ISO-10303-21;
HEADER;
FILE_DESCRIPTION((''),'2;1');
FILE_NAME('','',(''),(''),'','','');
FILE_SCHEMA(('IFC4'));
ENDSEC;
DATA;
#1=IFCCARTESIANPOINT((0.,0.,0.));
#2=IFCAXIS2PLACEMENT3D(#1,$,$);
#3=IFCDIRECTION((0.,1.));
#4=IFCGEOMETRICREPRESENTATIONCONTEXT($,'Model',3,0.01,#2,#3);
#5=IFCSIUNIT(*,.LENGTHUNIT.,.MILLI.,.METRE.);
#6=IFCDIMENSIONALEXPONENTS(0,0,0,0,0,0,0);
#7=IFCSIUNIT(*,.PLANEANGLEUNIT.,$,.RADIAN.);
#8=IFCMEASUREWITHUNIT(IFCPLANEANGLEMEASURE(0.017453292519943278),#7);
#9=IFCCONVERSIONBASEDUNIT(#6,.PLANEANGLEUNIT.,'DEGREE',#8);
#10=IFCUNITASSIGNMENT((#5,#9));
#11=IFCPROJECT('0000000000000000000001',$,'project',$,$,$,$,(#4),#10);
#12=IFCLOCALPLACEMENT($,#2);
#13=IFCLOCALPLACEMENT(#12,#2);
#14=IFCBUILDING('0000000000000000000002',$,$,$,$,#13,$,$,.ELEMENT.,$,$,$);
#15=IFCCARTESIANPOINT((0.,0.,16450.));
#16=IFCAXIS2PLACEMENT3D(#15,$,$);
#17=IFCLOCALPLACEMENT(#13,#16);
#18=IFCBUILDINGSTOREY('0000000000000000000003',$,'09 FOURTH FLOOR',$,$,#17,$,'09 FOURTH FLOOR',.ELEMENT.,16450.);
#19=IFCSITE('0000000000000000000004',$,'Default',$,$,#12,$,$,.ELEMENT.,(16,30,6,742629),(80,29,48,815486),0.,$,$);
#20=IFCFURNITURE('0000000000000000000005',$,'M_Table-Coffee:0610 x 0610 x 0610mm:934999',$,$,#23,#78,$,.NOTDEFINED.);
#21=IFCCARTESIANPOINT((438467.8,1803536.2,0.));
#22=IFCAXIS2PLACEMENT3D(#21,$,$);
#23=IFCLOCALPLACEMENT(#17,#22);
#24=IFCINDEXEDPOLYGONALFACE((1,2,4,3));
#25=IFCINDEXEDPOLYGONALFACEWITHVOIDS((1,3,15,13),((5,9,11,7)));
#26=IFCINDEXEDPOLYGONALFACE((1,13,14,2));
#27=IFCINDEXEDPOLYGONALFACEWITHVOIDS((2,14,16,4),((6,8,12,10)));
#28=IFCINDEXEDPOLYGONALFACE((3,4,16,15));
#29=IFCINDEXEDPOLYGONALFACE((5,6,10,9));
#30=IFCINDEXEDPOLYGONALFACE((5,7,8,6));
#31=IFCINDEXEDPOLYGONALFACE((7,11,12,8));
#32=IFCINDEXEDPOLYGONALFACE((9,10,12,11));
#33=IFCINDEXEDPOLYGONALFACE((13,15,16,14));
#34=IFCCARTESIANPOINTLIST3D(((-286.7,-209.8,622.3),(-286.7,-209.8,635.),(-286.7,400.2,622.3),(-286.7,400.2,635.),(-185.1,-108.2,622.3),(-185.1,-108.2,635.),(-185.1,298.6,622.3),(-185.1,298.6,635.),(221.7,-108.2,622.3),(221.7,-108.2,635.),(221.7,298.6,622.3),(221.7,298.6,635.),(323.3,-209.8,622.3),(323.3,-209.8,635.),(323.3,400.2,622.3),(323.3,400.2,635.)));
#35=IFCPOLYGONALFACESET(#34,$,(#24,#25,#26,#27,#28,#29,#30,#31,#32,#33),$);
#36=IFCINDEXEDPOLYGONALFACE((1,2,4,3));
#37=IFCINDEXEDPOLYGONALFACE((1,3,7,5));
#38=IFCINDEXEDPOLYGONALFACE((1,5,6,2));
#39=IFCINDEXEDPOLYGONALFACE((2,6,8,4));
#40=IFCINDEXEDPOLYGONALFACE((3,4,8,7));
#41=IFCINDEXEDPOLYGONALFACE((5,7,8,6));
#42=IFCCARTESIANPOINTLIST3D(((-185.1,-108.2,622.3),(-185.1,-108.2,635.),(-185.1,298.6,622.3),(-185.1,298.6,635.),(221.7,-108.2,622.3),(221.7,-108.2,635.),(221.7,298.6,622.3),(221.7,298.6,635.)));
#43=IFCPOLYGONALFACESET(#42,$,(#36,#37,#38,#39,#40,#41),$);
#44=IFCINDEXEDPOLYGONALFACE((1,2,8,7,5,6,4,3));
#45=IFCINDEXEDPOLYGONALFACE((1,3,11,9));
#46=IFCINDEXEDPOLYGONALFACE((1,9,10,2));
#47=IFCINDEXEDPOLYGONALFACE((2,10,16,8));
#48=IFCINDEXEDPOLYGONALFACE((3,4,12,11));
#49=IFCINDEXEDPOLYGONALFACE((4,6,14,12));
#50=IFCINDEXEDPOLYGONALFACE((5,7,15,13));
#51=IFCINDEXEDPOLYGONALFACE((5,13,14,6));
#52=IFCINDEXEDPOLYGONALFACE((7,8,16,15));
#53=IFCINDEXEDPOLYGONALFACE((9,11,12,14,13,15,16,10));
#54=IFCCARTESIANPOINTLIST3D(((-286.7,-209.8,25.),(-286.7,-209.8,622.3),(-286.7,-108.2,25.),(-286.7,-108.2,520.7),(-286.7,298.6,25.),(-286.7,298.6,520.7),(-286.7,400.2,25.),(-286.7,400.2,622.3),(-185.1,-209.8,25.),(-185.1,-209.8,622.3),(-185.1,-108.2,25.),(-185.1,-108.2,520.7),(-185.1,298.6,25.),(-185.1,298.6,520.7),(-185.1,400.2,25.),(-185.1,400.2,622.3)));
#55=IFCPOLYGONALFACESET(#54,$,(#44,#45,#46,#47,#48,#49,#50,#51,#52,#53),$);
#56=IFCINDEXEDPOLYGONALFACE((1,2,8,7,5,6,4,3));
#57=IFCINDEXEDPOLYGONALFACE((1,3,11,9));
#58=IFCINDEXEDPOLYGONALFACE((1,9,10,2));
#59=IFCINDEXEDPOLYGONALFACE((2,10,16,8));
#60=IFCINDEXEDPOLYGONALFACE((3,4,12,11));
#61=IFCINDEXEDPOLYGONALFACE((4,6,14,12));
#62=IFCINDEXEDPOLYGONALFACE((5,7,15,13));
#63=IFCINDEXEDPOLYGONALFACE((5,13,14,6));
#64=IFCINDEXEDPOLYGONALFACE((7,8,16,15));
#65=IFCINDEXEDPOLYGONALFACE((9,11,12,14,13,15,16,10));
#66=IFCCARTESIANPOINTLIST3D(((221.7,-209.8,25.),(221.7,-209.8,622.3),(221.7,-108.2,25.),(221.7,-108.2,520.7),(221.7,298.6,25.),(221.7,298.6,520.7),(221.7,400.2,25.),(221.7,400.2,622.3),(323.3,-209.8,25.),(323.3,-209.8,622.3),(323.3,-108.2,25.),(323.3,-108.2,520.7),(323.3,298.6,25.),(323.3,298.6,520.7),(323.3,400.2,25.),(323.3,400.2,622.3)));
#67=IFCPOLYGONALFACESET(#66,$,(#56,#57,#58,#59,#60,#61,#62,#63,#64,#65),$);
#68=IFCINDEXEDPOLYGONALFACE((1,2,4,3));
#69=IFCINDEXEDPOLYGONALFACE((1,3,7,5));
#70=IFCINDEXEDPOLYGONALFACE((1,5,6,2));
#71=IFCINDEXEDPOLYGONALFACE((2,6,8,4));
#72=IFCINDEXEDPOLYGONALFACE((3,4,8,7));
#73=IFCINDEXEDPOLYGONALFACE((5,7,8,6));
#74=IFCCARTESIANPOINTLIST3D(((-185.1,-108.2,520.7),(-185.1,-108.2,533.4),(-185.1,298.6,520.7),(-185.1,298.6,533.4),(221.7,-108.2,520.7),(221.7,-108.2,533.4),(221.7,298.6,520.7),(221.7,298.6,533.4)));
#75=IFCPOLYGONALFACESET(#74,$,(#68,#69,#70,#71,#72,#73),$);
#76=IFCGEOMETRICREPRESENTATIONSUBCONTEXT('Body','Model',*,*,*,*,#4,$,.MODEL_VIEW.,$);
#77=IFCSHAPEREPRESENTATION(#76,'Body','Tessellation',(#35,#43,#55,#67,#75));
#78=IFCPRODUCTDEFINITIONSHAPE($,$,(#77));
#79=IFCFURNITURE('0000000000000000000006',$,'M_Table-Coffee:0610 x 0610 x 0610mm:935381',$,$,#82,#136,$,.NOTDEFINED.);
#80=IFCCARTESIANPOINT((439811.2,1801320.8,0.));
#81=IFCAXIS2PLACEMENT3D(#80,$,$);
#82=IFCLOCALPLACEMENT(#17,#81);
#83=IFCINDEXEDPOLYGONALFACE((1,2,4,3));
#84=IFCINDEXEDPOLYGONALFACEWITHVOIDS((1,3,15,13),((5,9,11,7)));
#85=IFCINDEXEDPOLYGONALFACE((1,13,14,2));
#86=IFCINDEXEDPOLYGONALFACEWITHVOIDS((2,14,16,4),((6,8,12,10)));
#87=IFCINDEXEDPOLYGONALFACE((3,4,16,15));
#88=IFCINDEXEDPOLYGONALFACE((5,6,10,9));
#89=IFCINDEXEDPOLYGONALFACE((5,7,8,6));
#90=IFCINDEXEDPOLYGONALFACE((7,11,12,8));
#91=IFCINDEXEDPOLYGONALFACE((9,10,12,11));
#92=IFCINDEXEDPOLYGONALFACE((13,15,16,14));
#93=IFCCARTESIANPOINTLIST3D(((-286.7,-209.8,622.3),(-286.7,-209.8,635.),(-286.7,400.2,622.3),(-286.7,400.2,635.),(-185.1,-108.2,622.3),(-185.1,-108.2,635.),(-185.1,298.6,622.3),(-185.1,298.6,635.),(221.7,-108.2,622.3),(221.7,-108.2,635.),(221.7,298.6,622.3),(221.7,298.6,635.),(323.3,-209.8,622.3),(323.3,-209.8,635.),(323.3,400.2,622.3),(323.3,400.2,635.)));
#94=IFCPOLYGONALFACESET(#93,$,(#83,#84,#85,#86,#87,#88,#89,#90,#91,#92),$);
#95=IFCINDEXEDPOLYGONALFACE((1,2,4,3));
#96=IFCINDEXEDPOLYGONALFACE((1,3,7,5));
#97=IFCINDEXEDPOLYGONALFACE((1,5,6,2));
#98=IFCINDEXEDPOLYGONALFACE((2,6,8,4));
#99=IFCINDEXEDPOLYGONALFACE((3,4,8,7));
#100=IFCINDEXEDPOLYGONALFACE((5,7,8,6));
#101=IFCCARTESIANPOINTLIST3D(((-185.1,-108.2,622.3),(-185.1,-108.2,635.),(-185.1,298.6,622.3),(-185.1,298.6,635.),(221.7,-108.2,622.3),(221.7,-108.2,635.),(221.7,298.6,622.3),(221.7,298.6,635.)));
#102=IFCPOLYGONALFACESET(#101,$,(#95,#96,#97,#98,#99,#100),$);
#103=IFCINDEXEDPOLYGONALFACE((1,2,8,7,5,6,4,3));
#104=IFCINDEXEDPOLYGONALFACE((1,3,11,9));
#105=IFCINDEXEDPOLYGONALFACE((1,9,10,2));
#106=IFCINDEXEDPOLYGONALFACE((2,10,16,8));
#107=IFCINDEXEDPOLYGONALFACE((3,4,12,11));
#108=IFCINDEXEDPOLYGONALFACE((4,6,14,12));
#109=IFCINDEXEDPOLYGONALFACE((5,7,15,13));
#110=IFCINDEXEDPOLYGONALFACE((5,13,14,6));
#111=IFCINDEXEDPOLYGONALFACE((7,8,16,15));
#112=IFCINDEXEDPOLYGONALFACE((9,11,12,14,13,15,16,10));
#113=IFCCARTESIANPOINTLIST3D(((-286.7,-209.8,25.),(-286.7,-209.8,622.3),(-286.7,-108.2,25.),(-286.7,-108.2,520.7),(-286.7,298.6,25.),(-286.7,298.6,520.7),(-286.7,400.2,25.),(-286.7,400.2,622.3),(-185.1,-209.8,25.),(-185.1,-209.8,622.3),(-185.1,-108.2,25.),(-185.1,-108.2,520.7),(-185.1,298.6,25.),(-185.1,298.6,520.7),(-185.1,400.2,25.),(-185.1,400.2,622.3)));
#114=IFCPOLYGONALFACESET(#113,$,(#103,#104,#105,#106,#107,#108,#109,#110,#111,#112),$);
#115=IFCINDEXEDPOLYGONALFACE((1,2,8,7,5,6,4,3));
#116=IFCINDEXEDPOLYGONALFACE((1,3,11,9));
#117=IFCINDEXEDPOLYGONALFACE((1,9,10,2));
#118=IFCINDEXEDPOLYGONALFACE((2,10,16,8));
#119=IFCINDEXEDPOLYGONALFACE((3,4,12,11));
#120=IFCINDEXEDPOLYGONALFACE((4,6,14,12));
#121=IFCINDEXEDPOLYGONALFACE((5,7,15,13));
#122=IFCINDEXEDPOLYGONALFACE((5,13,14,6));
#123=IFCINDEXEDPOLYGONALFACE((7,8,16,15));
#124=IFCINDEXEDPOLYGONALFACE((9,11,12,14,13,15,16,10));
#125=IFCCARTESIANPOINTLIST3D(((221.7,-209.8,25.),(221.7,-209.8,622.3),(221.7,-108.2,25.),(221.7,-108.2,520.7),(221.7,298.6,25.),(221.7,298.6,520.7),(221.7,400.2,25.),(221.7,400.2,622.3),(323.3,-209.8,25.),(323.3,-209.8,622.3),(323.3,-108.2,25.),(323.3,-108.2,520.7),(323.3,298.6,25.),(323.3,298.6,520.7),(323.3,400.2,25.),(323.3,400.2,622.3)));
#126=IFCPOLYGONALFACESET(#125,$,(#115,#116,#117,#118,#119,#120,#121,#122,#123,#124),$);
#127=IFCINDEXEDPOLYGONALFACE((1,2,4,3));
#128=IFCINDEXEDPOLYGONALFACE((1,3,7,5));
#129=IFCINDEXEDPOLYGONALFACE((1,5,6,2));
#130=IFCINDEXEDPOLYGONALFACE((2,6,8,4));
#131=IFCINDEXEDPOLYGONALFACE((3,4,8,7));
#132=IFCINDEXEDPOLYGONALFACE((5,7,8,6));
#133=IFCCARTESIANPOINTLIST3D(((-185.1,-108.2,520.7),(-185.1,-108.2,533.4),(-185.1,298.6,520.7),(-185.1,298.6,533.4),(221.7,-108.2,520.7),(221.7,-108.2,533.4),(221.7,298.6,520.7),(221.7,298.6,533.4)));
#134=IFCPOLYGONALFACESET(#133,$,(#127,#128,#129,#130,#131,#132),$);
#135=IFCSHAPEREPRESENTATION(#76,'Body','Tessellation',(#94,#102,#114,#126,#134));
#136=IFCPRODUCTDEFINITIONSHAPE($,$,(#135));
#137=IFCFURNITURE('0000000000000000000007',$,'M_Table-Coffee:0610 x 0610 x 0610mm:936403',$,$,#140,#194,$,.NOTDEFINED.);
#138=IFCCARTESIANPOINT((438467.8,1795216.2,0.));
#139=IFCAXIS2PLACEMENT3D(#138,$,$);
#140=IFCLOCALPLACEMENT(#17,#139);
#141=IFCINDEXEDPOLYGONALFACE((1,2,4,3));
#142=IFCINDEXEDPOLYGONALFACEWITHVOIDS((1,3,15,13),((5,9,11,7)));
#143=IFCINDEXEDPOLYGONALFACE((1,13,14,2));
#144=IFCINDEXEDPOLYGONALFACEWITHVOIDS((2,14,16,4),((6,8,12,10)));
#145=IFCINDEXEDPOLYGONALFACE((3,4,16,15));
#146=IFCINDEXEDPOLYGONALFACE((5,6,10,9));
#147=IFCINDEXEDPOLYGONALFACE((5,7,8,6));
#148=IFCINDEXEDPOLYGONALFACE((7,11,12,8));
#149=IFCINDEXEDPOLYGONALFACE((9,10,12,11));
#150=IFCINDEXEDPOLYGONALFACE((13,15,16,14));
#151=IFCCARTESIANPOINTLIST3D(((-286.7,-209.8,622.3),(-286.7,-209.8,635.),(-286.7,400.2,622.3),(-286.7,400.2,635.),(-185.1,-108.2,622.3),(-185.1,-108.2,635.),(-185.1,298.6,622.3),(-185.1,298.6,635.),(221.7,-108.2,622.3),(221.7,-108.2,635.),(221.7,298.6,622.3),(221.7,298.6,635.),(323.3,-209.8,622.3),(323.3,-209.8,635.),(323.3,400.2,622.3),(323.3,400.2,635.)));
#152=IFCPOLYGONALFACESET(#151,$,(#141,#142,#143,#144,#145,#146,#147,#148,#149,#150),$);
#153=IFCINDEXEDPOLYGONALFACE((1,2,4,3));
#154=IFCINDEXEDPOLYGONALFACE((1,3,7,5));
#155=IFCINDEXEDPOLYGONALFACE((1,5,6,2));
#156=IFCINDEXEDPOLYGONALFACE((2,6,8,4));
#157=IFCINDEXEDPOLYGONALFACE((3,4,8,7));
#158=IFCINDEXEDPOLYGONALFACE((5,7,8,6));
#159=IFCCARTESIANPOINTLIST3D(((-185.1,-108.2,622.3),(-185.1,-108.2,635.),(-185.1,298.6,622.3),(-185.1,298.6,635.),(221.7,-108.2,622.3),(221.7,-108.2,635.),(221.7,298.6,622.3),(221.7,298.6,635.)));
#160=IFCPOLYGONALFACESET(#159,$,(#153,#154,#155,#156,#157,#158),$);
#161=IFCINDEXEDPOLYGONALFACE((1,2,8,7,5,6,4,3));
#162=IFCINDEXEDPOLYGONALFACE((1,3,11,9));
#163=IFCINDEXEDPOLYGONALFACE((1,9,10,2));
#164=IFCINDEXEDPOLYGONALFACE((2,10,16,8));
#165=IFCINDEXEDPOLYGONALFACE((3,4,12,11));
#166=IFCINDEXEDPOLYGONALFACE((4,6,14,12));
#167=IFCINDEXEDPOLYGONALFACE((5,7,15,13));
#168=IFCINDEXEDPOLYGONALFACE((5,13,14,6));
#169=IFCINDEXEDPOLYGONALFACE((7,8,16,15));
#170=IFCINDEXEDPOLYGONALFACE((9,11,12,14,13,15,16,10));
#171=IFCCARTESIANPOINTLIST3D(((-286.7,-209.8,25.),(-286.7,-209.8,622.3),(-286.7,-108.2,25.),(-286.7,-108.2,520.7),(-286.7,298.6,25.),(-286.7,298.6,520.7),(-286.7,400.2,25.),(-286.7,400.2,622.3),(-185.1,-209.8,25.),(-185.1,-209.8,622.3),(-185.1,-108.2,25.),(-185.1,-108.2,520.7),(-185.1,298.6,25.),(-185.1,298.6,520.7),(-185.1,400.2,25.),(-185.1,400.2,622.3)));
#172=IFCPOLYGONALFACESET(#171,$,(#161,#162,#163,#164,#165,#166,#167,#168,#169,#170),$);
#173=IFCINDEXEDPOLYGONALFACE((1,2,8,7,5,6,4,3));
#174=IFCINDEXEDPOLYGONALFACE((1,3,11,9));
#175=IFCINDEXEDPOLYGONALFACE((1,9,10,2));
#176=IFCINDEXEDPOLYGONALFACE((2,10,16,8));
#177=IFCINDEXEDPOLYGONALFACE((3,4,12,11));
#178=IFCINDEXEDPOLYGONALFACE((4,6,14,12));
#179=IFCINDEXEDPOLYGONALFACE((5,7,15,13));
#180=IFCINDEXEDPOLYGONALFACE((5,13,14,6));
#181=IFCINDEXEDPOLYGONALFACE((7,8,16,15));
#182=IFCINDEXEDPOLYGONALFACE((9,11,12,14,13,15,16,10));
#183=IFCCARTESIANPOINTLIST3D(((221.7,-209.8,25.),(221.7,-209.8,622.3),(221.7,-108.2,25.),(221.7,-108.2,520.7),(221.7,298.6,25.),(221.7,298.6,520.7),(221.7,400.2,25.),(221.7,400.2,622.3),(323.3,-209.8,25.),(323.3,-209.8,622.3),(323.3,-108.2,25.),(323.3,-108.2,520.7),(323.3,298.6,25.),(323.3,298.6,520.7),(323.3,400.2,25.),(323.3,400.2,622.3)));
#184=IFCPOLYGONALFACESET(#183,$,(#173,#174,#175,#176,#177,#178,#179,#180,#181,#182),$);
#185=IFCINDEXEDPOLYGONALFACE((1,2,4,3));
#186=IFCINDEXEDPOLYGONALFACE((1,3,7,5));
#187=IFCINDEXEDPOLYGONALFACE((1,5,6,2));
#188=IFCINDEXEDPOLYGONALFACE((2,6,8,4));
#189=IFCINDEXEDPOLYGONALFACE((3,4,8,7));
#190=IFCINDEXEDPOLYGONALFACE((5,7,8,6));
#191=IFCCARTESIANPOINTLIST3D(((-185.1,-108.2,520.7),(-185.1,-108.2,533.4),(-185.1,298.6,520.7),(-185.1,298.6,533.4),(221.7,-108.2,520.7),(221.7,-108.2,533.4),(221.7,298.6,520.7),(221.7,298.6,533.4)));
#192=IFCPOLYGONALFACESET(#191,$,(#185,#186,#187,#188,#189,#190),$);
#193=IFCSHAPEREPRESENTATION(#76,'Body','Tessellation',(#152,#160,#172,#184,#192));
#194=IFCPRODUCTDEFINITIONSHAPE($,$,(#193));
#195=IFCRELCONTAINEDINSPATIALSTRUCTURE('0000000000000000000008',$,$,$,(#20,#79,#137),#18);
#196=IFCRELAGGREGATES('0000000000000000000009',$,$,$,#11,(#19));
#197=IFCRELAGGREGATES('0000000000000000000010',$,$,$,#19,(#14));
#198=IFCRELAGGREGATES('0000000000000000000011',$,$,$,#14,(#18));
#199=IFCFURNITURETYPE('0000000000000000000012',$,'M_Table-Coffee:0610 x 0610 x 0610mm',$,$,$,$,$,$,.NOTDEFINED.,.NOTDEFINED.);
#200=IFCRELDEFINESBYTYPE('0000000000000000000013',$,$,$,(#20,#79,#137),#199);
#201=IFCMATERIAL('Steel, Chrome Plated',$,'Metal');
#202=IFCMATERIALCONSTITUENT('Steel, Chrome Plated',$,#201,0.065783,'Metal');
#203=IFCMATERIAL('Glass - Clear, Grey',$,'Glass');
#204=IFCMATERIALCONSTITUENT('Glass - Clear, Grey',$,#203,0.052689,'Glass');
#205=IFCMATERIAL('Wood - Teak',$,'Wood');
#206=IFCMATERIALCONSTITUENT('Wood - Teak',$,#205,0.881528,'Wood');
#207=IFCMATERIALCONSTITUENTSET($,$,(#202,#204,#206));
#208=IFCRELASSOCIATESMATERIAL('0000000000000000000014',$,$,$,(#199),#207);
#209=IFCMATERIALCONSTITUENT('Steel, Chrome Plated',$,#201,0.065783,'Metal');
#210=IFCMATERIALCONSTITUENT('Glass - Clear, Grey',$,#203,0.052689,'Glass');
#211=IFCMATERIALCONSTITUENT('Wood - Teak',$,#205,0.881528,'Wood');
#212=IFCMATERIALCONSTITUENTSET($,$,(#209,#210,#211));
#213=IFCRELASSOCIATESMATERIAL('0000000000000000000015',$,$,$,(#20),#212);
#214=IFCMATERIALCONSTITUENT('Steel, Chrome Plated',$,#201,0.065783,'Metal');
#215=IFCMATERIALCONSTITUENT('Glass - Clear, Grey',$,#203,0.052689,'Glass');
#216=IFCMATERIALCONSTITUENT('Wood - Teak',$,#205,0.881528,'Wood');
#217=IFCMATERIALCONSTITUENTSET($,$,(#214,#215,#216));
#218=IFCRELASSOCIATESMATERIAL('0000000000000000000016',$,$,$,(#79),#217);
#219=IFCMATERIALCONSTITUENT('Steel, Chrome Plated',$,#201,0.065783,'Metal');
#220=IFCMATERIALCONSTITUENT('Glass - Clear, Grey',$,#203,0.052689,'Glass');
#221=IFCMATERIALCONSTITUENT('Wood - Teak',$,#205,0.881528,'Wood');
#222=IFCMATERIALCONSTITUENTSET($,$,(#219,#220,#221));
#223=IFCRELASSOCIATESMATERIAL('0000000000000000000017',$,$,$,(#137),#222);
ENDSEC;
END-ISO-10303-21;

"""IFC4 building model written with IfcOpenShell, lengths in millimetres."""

from ifc_helpers import new_model, entity, si_unit, converted_unit, direction, frame, origin, place, context, subcontext, project, spatial, indexed_curve, outline, extrude, source, transform, mapped, material, constituent, constituent_set, type_object, type_shapes, element, save


model = new_model("IFC4")

# Units and contexts
model_context = context("Model", 3, precision=0.01, world=origin(), true_north=direction((0.0, 1.0)))
body_context = subcontext(model_context, "Body", "Model", "MODEL_VIEW")
ifc_project = project(units=[si_unit("LENGTHUNIT", "METRE", prefix="MILLI"), converted_unit("PLANEANGLEUNIT", "DEGREE", entity("IfcPlaneAngleMeasure", 0.017453292519943278), si_unit("PLANEANGLEUNIT", "RADIAN"), dimensions=[0, 0, 0, 0, 0, 0, 0])], contexts=[model_context])

# Site, building, storey
site_placement = place(None, origin())
site = spatial("IfcSite", under=ifc_project, at=site_placement, Name="Default", CompositionType="ELEMENT", RefLatitude=(16, 30, 6, 742629), RefLongitude=(80, 29, 48, 815486), RefElevation=0.0)
building_placement = place(site_placement, origin())
building = spatial("IfcBuilding", under=site, at=building_placement, CompositionType="ELEMENT")
storey_placement = place(building_placement, frame((0.0, 0.0, 16450.0)))
storey = spatial("IfcBuildingStorey", under=building, at=storey_placement, Name="09 FOURTH FLOOR", LongName="09 FOURTH FLOOR", CompositionType="ELEMENT", Elevation=16450.0)

# Furniture
ifc_material_1 = material(Name="Steel, Chrome Plated", Category="Metal")
ifc_constituent_1 = constituent(ifc_material_1, Name="Steel, Chrome Plated", Category="Metal", fraction=0.065783)
ifc_material_2 = material(Name="Glass - Clear, Grey", Category="Glass")
ifc_constituent_2 = constituent(ifc_material_2, Name="Glass - Clear, Grey", Category="Glass", fraction=0.052689)
ifc_material_3 = material(Name="Wood - Teak", Category="Wood")
ifc_constituent_3 = constituent(ifc_material_3, Name="Wood - Teak", Category="Wood", fraction=0.881528)
ifc_constituent_set_1 = constituent_set(constituents=[ifc_constituent_1, ifc_constituent_2, ifc_constituent_3])
ifc_constituent_4 = constituent(ifc_material_1, Name="Steel, Chrome Plated", Category="Metal", fraction=0.065783)
ifc_constituent_5 = constituent(ifc_material_2, Name="Glass - Clear, Grey", Category="Glass", fraction=0.052689)
ifc_constituent_6 = constituent(ifc_material_3, Name="Wood - Teak", Category="Wood", fraction=0.881528)
ifc_constituent_set_2 = constituent_set(constituents=[ifc_constituent_4, ifc_constituent_5, ifc_constituent_6])
furniture_type_1 = type_object("IfcFurnitureType", Name="M_Table-Coffee:0610 x 0610 x 0610mm", AssemblyPlace="NOTDEFINED", PredefinedType="NOTDEFINED", material=ifc_constituent_set_2)
shared_shape_1 = source(origin(), body_context, "Body", "SweptSolid", [
    extrude(outline(indexed_curve([(-305.0, -305.0), (305.0, -305.0), (305.0, 305.0), (-305.0, 305.0), (-305.0, -305.0)], self_intersect=False), holes=[indexed_curve([(-203.4, -203.4), (-203.4, 203.4), (203.4, 203.4), (203.4, -203.4), (-203.4, -203.4)], self_intersect=False)]), frame((18.3, 95.2, 622.3), z_axis=(0.0, 0.0, 1.0), x_axis=(-1.0, 0.0, 0.0)), (0.0, 0.0, 1.0), 12.7),
    extrude(outline(indexed_curve([(-203.4, -203.4), (203.4, -203.4), (203.4, 203.4), (-203.4, 203.4), (-203.4, -203.4)], self_intersect=False)), frame((18.3, 95.2, 622.3), z_axis=(0.0, 0.0, 1.0), x_axis=(-1.0, 0.0, 0.0)), (0.0, 0.0, 1.0), 12.7),
    extrude(outline(indexed_curve([(-305.0, -324.1), (305.0, -324.1), (305.0, 273.3), (203.4, 273.3), (203.4, -222.4), (-203.4, -222.4), (-203.4, 273.3), (-305.0, 273.3), (-305.0, -324.1)], self_intersect=False)), frame((-286.7, 95.2, 298.3), z_axis=(1.0, 0.0, 0.0), x_axis=(0.0, -1.0, 0.0)), (0.0, 0.0, 1.0), 101.6),
    extrude(outline(indexed_curve([(-273.2, -305.0), (324.0, -305.0), (324.0, 305.0), (-273.2, 305.0), (-273.2, 203.4), (222.5, 203.4), (222.5, -203.4), (-273.2, -203.4), (-273.2, -305.0)], self_intersect=False)), frame((221.7, 95.2, 298.2), z_axis=(1.0, 0.0, 0.0), x_axis=(0.0, 0.0, 1.0)), (0.0, 0.0, 1.0), 101.6),
    extrude(outline(indexed_curve([(-203.4, -203.4), (203.4, -203.4), (203.4, 203.4), (-203.4, 203.4), (-203.4, -203.4)], self_intersect=False)), frame((18.3, 95.2, 520.7), z_axis=(0.0, 0.0, 1.0), x_axis=(-1.0, 0.0, 0.0)), (0.0, 0.0, 1.0), 12.7),
])
type_shapes(furniture_type_1, [shared_shape_1])
furniture_1_placement = place(storey_placement, frame((438467.8, 1803536.2, 0.0)))
element("IfcFurniture", 1, at=furniture_1_placement, inside=storey, type_object=furniture_type_1, material=ifc_constituent_set_1, Name="M_Table-Coffee:0610 x 0610 x 0610mm:934999", PredefinedType="NOTDEFINED", context=body_context, shape_type="MappedRepresentation", body=[
    mapped(shared_shape_1, transform((0.0, 0.0, 0.0), scale=1.0)),
])
ifc_constituent_7 = constituent(ifc_material_1, Name="Steel, Chrome Plated", Category="Metal", fraction=0.065783)
ifc_constituent_8 = constituent(ifc_material_2, Name="Glass - Clear, Grey", Category="Glass", fraction=0.052689)
ifc_constituent_9 = constituent(ifc_material_3, Name="Wood - Teak", Category="Wood", fraction=0.881528)
ifc_constituent_set_3 = constituent_set(constituents=[ifc_constituent_7, ifc_constituent_8, ifc_constituent_9])
furniture_2_placement = place(storey_placement, frame((439811.2, 1801320.8, 0.0)))
element("IfcFurniture", 2, at=furniture_2_placement, inside=storey, type_object=furniture_type_1, material=ifc_constituent_set_3, Name="M_Table-Coffee:0610 x 0610 x 0610mm:935381", PredefinedType="NOTDEFINED", context=body_context, shape_type="MappedRepresentation", body=[
    mapped(shared_shape_1, transform((0.0, 0.0, 0.0), scale=1.0)),
])
ifc_constituent_10 = constituent(ifc_material_1, Name="Steel, Chrome Plated", Category="Metal", fraction=0.065783)
ifc_constituent_11 = constituent(ifc_material_2, Name="Glass - Clear, Grey", Category="Glass", fraction=0.052689)
ifc_constituent_12 = constituent(ifc_material_3, Name="Wood - Teak", Category="Wood", fraction=0.881528)
ifc_constituent_set_4 = constituent_set(constituents=[ifc_constituent_10, ifc_constituent_11, ifc_constituent_12])
furniture_3_placement = place(storey_placement, frame((438467.8, 1795216.2, 0.0)))
element("IfcFurniture", 3, at=furniture_3_placement, inside=storey, type_object=furniture_type_1, material=ifc_constituent_set_4, Name="M_Table-Coffee:0610 x 0610 x 0610mm:936403", PredefinedType="NOTDEFINED", context=body_context, shape_type="MappedRepresentation", body=[
    mapped(shared_shape_1, transform((0.0, 0.0, 0.0), scale=1.0)),
])

save(model, "model.ifc")
